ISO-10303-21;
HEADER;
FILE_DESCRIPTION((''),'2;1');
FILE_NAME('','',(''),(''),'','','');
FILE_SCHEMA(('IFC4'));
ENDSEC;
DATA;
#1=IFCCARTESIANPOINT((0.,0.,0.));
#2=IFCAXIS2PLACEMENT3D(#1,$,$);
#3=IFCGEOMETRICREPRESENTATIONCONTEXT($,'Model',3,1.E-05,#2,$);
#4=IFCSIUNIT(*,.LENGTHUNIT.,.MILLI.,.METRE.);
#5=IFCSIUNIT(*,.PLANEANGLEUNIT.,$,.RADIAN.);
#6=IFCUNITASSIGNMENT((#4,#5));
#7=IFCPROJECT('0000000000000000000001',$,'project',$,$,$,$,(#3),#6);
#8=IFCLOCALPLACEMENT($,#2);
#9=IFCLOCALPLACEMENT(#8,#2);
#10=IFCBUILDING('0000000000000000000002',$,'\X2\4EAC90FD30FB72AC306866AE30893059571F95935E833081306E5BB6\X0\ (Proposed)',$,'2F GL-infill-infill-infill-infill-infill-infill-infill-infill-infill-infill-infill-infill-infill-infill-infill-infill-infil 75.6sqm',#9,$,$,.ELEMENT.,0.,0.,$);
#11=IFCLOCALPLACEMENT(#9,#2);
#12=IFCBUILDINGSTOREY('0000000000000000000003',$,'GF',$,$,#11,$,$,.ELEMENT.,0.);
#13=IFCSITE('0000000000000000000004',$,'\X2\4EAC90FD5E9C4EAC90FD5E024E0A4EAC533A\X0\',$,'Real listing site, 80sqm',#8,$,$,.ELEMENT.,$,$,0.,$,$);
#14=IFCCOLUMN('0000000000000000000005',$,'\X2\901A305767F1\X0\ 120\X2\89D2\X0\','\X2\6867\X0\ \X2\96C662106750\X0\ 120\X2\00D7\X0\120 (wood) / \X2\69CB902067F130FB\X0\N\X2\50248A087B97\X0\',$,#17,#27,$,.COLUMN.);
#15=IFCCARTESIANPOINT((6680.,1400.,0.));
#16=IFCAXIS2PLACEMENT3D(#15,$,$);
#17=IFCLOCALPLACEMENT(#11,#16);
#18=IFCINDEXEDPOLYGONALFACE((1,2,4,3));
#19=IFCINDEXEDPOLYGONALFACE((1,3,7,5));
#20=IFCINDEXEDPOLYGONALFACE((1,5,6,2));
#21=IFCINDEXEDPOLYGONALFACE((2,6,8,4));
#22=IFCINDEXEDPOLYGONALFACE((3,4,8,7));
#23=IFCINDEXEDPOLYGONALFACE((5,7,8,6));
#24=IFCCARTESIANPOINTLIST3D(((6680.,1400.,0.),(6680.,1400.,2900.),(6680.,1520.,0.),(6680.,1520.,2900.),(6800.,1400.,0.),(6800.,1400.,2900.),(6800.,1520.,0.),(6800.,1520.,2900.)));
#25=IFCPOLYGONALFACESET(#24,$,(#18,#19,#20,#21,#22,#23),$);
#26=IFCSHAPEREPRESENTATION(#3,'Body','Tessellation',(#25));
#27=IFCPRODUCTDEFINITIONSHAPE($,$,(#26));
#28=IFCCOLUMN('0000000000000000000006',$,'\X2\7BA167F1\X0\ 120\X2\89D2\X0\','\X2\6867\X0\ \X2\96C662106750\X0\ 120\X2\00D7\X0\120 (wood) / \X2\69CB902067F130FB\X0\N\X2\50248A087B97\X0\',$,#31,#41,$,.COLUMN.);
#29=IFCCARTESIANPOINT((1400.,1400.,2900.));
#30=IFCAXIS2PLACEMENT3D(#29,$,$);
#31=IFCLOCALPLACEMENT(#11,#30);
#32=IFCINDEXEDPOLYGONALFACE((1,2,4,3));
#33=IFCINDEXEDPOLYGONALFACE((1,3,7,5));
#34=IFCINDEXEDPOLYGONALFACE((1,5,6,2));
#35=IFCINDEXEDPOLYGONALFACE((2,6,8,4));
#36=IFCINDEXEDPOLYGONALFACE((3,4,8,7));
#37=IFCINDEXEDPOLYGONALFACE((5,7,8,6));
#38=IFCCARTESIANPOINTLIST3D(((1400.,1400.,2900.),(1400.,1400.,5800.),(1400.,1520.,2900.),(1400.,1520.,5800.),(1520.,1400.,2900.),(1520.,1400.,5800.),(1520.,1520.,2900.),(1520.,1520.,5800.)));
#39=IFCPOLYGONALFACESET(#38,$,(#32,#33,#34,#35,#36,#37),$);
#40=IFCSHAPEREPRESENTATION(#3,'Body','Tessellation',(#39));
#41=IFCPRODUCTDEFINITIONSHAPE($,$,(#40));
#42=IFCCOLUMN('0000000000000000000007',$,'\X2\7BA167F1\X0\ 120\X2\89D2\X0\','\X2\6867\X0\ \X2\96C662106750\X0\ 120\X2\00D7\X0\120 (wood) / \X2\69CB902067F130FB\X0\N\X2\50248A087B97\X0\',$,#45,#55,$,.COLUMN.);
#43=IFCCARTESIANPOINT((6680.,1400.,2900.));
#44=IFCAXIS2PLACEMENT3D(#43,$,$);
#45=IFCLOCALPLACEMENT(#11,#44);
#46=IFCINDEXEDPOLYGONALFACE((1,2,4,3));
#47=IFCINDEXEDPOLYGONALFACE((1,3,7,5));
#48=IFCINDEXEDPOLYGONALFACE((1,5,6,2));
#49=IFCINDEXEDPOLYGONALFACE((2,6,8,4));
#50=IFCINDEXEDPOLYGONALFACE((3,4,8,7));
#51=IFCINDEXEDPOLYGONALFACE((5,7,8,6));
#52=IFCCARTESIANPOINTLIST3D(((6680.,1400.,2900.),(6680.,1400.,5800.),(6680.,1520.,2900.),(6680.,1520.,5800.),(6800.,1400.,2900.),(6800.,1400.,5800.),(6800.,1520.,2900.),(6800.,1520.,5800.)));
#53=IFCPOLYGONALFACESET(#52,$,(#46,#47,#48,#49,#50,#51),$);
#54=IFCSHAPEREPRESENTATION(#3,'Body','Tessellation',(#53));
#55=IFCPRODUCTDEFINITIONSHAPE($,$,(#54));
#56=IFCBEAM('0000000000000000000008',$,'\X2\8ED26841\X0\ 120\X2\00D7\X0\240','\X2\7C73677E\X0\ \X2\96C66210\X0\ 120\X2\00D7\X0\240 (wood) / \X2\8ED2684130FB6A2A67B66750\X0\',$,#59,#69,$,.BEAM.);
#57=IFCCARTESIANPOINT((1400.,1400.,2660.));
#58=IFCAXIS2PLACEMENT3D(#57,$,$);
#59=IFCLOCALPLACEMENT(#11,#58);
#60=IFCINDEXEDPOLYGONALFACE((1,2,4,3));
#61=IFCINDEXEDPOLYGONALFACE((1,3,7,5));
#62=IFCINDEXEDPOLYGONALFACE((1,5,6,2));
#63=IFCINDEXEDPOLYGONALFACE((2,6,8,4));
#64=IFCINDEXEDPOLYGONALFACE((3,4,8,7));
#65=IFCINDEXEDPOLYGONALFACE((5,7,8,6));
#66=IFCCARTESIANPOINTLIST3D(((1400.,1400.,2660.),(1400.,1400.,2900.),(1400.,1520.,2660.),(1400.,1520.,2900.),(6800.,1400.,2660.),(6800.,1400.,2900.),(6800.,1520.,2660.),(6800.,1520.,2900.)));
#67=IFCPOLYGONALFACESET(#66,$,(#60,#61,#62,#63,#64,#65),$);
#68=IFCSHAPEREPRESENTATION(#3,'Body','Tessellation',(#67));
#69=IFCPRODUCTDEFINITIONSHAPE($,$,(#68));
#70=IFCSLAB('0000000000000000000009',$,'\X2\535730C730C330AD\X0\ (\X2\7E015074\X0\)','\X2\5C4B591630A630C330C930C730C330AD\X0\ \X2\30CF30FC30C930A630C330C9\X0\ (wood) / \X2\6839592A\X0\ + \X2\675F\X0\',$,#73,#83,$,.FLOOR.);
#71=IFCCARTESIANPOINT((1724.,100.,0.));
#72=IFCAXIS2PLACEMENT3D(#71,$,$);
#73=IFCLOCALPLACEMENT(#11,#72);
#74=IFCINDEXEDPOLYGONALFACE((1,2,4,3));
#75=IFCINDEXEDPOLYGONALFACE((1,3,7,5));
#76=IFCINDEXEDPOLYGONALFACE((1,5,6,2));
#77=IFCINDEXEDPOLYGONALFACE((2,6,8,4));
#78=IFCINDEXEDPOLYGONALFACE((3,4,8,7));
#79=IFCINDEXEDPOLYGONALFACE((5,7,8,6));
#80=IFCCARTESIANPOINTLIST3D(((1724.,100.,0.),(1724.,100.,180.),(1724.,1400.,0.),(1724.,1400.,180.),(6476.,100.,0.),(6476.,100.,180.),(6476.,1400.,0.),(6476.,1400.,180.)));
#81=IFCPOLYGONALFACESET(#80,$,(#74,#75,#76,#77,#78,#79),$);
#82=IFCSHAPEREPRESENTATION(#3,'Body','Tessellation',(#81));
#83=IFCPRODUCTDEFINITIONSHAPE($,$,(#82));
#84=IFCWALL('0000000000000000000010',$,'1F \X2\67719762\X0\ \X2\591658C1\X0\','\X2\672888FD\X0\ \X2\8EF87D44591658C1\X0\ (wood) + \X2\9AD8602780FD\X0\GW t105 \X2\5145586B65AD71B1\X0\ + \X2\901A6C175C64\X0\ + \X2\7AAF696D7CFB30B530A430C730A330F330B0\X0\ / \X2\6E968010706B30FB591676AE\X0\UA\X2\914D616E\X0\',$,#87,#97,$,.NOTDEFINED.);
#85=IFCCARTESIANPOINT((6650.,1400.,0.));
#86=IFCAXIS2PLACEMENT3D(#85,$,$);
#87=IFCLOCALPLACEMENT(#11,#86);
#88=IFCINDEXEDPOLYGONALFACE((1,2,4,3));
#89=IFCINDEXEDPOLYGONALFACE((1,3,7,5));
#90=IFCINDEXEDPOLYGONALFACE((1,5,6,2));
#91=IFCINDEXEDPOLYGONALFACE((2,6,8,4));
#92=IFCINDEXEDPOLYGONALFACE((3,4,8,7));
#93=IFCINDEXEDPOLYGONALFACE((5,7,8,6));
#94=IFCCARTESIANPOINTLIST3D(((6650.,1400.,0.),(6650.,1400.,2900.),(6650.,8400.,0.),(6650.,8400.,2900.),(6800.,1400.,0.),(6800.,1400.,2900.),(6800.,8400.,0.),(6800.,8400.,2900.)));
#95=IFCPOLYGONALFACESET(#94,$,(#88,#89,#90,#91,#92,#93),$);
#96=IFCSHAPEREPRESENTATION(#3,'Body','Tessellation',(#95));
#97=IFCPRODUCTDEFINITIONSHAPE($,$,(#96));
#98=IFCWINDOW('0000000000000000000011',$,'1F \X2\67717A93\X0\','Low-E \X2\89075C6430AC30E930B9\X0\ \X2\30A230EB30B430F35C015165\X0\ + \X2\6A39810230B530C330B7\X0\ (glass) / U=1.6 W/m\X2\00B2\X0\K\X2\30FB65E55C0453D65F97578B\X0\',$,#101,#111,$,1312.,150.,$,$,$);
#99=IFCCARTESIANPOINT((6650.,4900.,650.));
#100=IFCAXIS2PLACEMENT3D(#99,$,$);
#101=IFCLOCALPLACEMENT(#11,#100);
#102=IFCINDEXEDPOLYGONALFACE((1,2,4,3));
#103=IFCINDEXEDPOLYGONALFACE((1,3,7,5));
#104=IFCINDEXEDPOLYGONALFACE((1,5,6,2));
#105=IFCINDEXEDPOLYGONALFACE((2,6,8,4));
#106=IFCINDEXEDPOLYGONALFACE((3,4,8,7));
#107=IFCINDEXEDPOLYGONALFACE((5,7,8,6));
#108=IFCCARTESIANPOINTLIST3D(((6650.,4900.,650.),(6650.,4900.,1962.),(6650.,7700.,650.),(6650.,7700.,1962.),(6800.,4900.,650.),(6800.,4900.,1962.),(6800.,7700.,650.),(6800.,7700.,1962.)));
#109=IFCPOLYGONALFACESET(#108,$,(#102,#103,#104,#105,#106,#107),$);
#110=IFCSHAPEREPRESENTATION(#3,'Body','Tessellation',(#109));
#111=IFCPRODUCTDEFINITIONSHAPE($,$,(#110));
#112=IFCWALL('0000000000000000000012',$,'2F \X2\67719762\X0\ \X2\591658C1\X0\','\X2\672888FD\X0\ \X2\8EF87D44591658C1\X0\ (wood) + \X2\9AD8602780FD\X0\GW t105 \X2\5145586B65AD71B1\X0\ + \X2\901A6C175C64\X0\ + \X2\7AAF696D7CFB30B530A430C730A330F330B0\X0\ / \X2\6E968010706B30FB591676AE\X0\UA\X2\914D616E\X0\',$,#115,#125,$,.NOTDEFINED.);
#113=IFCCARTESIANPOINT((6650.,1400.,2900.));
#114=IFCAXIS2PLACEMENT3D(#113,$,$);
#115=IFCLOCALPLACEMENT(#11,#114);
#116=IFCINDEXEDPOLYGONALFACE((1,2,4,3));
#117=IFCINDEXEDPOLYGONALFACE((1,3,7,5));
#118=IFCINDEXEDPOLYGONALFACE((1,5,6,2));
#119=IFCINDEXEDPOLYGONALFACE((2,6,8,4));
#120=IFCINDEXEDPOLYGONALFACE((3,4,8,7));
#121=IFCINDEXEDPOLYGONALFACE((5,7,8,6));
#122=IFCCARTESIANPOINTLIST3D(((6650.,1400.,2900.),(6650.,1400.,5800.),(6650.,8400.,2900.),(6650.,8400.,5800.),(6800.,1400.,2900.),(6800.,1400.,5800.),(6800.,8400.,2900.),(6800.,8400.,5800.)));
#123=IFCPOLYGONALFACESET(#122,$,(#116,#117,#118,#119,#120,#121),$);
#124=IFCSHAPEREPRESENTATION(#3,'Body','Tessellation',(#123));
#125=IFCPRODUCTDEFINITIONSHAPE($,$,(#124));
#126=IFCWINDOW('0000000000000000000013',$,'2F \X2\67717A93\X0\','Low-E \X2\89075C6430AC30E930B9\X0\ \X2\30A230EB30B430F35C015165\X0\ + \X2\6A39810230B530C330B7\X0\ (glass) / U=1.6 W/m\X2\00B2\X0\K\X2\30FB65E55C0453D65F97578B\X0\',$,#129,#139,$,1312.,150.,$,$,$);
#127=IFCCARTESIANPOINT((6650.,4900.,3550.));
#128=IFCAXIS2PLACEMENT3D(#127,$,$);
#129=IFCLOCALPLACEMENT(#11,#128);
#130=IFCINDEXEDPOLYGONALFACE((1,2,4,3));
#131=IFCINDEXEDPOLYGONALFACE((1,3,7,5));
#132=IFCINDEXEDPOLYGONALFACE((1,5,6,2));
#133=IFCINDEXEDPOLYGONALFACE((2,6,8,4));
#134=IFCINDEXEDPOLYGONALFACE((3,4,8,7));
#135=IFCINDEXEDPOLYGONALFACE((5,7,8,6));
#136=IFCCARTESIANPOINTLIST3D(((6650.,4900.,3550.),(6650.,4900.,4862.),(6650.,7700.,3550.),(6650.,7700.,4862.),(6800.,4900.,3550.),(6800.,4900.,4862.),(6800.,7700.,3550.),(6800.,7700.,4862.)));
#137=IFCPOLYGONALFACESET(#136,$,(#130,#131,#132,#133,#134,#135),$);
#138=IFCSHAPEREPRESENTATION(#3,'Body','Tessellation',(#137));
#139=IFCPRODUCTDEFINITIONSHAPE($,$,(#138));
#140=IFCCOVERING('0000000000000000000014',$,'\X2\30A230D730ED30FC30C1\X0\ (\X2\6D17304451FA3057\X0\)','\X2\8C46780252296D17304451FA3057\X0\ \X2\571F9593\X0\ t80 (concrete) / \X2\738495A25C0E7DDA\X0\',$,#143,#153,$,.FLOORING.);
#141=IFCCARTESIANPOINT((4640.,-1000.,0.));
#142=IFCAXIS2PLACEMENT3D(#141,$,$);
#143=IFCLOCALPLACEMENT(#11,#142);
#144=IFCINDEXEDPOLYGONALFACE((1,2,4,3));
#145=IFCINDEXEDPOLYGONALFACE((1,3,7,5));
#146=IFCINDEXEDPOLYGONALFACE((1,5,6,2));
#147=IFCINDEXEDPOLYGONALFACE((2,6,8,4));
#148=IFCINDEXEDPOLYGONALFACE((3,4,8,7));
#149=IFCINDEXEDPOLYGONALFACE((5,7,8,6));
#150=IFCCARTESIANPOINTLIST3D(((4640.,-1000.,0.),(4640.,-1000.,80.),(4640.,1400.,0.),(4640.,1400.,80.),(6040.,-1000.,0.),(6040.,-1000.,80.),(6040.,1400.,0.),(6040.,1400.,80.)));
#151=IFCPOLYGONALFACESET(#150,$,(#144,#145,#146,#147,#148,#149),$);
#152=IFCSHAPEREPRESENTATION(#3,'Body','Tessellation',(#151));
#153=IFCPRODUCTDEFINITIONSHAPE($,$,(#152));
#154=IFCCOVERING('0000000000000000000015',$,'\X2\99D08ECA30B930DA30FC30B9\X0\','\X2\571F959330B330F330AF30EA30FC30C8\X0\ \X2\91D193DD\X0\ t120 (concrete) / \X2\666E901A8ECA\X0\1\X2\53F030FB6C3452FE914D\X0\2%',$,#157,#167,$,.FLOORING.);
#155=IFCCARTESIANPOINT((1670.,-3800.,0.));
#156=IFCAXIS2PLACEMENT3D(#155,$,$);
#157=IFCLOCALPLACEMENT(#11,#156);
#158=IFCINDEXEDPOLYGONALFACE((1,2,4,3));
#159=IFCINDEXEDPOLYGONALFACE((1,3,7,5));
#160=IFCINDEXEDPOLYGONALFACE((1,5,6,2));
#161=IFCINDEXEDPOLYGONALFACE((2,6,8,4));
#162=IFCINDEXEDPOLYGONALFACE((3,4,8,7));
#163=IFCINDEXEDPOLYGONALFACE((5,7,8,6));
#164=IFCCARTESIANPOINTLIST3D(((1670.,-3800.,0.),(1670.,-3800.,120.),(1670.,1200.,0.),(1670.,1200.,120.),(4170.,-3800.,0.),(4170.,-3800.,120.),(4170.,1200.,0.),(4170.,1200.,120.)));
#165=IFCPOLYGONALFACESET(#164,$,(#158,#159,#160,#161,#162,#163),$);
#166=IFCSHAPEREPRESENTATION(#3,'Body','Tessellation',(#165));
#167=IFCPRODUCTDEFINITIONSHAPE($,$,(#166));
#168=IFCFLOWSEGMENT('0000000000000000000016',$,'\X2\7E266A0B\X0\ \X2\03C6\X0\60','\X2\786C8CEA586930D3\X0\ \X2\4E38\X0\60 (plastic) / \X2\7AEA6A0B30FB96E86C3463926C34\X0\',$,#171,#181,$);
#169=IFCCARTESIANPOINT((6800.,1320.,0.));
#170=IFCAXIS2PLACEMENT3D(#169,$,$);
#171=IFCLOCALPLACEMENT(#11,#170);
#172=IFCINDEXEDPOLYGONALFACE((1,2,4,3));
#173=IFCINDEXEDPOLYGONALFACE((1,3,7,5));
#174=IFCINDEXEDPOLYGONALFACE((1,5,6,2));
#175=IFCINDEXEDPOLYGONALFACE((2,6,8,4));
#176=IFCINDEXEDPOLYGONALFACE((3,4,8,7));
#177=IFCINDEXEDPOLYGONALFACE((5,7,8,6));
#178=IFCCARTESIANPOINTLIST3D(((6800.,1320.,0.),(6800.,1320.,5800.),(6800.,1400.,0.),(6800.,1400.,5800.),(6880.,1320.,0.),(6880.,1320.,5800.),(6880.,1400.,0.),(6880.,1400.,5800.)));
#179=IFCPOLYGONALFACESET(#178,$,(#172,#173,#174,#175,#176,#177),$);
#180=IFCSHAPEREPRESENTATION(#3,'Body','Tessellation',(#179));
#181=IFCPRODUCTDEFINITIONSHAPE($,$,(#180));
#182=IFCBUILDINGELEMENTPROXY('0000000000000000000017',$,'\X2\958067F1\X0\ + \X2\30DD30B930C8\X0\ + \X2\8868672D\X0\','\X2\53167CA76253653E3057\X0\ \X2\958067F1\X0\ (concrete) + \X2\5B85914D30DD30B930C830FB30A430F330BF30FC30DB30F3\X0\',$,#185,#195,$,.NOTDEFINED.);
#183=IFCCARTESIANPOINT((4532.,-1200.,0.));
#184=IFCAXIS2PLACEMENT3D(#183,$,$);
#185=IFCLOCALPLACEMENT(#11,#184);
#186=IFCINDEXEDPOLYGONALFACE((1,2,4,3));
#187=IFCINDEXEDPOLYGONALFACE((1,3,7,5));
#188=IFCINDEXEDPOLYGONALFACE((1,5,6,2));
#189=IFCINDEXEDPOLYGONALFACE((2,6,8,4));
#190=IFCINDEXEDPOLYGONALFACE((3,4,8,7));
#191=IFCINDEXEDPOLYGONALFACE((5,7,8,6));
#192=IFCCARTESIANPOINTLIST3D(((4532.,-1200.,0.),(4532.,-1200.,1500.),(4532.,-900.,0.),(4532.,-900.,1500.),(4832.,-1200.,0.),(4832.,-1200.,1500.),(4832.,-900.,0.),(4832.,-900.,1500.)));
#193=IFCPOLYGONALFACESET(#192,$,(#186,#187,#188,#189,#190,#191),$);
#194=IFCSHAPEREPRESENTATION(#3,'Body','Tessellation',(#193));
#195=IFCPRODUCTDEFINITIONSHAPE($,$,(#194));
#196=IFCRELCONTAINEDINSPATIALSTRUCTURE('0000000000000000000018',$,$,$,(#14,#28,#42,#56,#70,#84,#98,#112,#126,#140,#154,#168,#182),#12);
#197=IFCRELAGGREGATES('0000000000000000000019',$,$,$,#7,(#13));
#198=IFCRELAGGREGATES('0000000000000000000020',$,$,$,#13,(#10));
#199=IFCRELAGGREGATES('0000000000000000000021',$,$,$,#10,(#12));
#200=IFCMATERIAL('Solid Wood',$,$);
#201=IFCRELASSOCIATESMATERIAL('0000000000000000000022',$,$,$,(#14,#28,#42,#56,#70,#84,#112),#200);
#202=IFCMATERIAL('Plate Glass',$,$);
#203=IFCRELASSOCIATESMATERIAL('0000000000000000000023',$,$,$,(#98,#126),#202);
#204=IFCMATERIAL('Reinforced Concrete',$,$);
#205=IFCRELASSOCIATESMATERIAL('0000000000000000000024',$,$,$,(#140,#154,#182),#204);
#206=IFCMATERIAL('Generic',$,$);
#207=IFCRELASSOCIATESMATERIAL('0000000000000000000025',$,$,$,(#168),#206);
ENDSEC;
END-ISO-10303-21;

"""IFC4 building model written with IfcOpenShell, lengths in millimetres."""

from ifc_helpers import new_model, si_unit, frame, frame_2d, origin, place, context, project, spatial, rectangle, extrude, material, element, fill, save


model = new_model("IFC4")

# Units and contexts
model_context = context("Model", 3, precision=1e-05, world=origin())
ifc_project = project(units=[si_unit("LENGTHUNIT", "METRE", prefix="MILLI"), si_unit("PLANEANGLEUNIT", "RADIAN")], contexts=[model_context])

# Site, building, storey
site_placement = place(None, origin())
site = spatial("IfcSite", under=ifc_project, at=site_placement, Name="京都府京都市上京区", ObjectType="Real listing site, 80sqm", CompositionType="ELEMENT", RefElevation=0.0)
building_placement = place(site_placement, origin())
building = spatial("IfcBuilding", under=site, at=building_placement, Name="京都・犬と暮らす土間広めの家 (Proposed)", ObjectType="2F GL-infill-infill-infill-infill-infill-infill-infill-infill-infill-infill-infill-infill-infill-infill-infill-infill-infil 75.6sqm", CompositionType="ELEMENT", ElevationOfRefHeight=0.0, ElevationOfTerrain=0.0)
storey_placement = place(building_placement, origin())
storey = spatial("IfcBuildingStorey", under=building, at=storey_placement, Name="GF", CompositionType="ELEMENT", Elevation=0.0)

# Columns
ifc_material_1 = material(Name="Solid Wood")
column_1_placement = place(storey_placement, frame((6680.0, 1400.0, 0.0)))
element("IfcColumn", 1, at=column_1_placement, inside=storey, material=ifc_material_1, Name="通し柱 120角", Description="桧 集成材 120×120 (wood) / 構造柱・N値計算", PredefinedType="COLUMN", context=model_context, shape_type="SweptSolid", body=[
    extrude(rectangle(XDim=120.0, YDim=120.0, at=frame_2d((60.0, 60.0))), frame((6680.0, 1400.0, 0.0)), (0.0, 0.0, 1.0), 2900.0),
])
column_2_placement = place(storey_placement, frame((1400.0, 1400.0, 2900.0)))
element("IfcColumn", 2, at=column_2_placement, inside=storey, material=ifc_material_1, Name="管柱 120角", Description="桧 集成材 120×120 (wood) / 構造柱・N値計算", PredefinedType="COLUMN", context=model_context, shape_type="SweptSolid", body=[
    extrude(rectangle(XDim=120.0, YDim=120.0, at=frame_2d((60.0, 60.0))), frame((1400.0, 1400.0, 2900.0)), (0.0, 0.0, 1.0), 2900.0),
])
column_3_placement = place(storey_placement, frame((6680.0, 1400.0, 2900.0)))
element("IfcColumn", 3, at=column_3_placement, inside=storey, material=ifc_material_1, Name="管柱 120角", Description="桧 集成材 120×120 (wood) / 構造柱・N値計算", PredefinedType="COLUMN", context=model_context, shape_type="SweptSolid", body=[
    extrude(rectangle(XDim=120.0, YDim=120.0, at=frame_2d((60.0, 60.0))), frame((6680.0, 1400.0, 2900.0)), (0.0, 0.0, 1.0), 2900.0),
])

# Beam
beam_1_placement = place(storey_placement, frame((1400.0, 1400.0, 2660.0)))
element("IfcBeam", 4, at=beam_1_placement, inside=storey, material=ifc_material_1, Name="軒桁 120×240", Description="米松 集成 120×240 (wood) / 軒桁・横架材", PredefinedType="BEAM", context=model_context, shape_type="SweptSolid", body=[
    extrude(rectangle(XDim=5400.0, YDim=120.0, at=frame_2d((2700.0, 60.0))), frame((1400.0, 1400.0, 2660.0)), (0.0, 0.0, 1.0), 240.0),
])

# Slab
slab_placement = place(storey_placement, frame((1724.0, 100.0, 0.0)))
element("IfcSlab", 5, at=slab_placement, inside=storey, material=ifc_material_1, Name="南デッキ (縁側)", Description="屋外ウッドデッキ ハードウッド (wood) / 根太 + 束", PredefinedType="FLOOR", context=model_context, shape_type="SweptSolid", body=[
    extrude(rectangle(XDim=4752.0, YDim=1300.0, at=frame_2d((2376.0, 650.0))), frame((1724.0, 100.0, 0.0)), (0.0, 0.0, 1.0), 180.0),
])

# Walls, openings, windows
wall_1_placement = place(storey_placement, frame((6650.0, 1400.0, 0.0)))
wall_1 = element("IfcWall", 6, at=wall_1_placement, inside=storey, material=ifc_material_1, Name="1F 東面 外壁", Description="木製 軸組外壁 (wood) + 高性能GW t105 充填断熱 + 通気層 + 窯業系サイディング / 準耐火・外皮UA配慮", PredefinedType="NOTDEFINED", context=model_context, shape_type="SweptSolid", body=[
    extrude(rectangle(XDim=150.0, YDim=7000.0, at=frame_2d((75.0, 3500.0))), frame((6650.0, 1400.0, 0.0)), (0.0, 0.0, 1.0), 2900.0),
])
opening_1_placement = place(storey_placement, frame((6650.0, 4900.0, 650.0)))
opening_1 = element("IfcOpeningElement", 7, at=opening_1_placement, cuts=wall_1, PredefinedType="NOTDEFINED", context=model_context, shape_type="SweptSolid", body=[
    extrude(rectangle(XDim=150.0, YDim=2800.0, at=frame_2d((75.0, 1400.0))), frame((6650.0, 4900.0, 650.0)), (0.0, 0.0, 1.0), 1312.0),
])
ifc_material_2 = material(Name="Plate Glass")
window_1_placement = place(storey_placement, frame((6650.0, 4900.0, 650.0)))
window_1 = element("IfcWindow", 8, at=window_1_placement, inside=storey, material=ifc_material_2, Name="1F 東窓", Description="Low-E 複層ガラス アルゴン封入 + 樹脂サッシ (glass) / U=1.6 W/m²K・日射取得型", OverallHeight=1312.0, OverallWidth=150.0, context=model_context, shape_type="SweptSolid", body=[
    extrude(rectangle(XDim=150.0, YDim=2800.0, at=frame_2d((75.0, 1400.0))), frame((6650.0, 4900.0, 650.0)), (0.0, 0.0, 1.0), 1312.0),
])
fill(opening_1, window_1)
wall_2_placement = place(storey_placement, frame((6650.0, 1400.0, 2900.0)))
wall_2 = element("IfcWall", 9, at=wall_2_placement, inside=storey, material=ifc_material_1, Name="2F 東面 外壁", Description="木製 軸組外壁 (wood) + 高性能GW t105 充填断熱 + 通気層 + 窯業系サイディング / 準耐火・外皮UA配慮", PredefinedType="NOTDEFINED", context=model_context, shape_type="SweptSolid", body=[
    extrude(rectangle(XDim=150.0, YDim=7000.0, at=frame_2d((75.0, 3500.0))), frame((6650.0, 1400.0, 2900.0)), (0.0, 0.0, 1.0), 2900.0),
])
opening_2_placement = place(storey_placement, frame((6650.0, 4900.0, 3550.0)))
opening_2 = element("IfcOpeningElement", 10, at=opening_2_placement, cuts=wall_2, PredefinedType="NOTDEFINED", context=model_context, shape_type="SweptSolid", body=[
    extrude(rectangle(XDim=150.0, YDim=2800.0, at=frame_2d((75.0, 1400.0))), frame((6650.0, 4900.0, 3550.0)), (0.0, 0.0, 1.0), 1312.0),
])
window_2_placement = place(storey_placement, frame((6650.0, 4900.0, 3550.0)))
window_2 = element("IfcWindow", 11, at=window_2_placement, inside=storey, material=ifc_material_2, Name="2F 東窓", Description="Low-E 複層ガラス アルゴン封入 + 樹脂サッシ (glass) / U=1.6 W/m²K・日射取得型", OverallHeight=1312.0, OverallWidth=150.0, context=model_context, shape_type="SweptSolid", body=[
    extrude(rectangle(XDim=150.0, YDim=2800.0, at=frame_2d((75.0, 1400.0))), frame((6650.0, 4900.0, 3550.0)), (0.0, 0.0, 1.0), 1312.0),
])
fill(opening_2, window_2)

# Coverings
ifc_material_3 = material(Name="Reinforced Concrete")
covering_1_placement = place(storey_placement, frame((4640.0, -1000.0, 0.0)))
element("IfcCovering", 12, at=covering_1_placement, inside=storey, material=ifc_material_3, Name="アプローチ (洗い出し)", Description="豆砂利洗い出し 土間 t80 (concrete) / 玄関導線", PredefinedType="FLOORING", context=model_context, shape_type="SweptSolid", body=[
    extrude(rectangle(XDim=1400.0, YDim=2400.0, at=frame_2d((700.0, 1200.0))), frame((4640.0, -1000.0, 0.0)), (0.0, 0.0, 1.0), 80.0),
])
covering_2_placement = place(storey_placement, frame((1670.0, -3800.0, 0.0)))
element("IfcCovering", 13, at=covering_2_placement, inside=storey, material=ifc_material_3, Name="駐車スペース", Description="土間コンクリート 金鏝 t120 (concrete) / 普通車1台・水勾配2%", PredefinedType="FLOORING", context=model_context, shape_type="SweptSolid", body=[
    extrude(rectangle(XDim=2500.0, YDim=5000.0, at=frame_2d((1250.0, 2500.0))), frame((1670.0, -3800.0, 0.0)), (0.0, 0.0, 1.0), 120.0),
])

# Flow segment
ifc_material_4 = material(Name="Generic")
flow_segment_placement = place(storey_placement, frame((6800.0, 1320.0, 0.0)))
element("IfcFlowSegment", 14, at=flow_segment_placement, inside=storey, material=ifc_material_4, Name="縦樋 φ60", Description="硬質塩ビ 丸60 (plastic) / 竪樋・雨水排水", context=model_context, shape_type="SweptSolid", body=[
    extrude(rectangle(XDim=80.0, YDim=80.0, at=frame_2d((40.0, 40.0))), frame((6800.0, 1320.0, 0.0)), (0.0, 0.0, 1.0), 5800.0),
])

# Building element proxy
proxy_placement = place(storey_placement, frame((4532.0, -1200.0, 0.0)))
element("IfcBuildingElementProxy", 15, at=proxy_placement, inside=storey, material=ifc_material_3, Name="門柱 + ポスト + 表札", Description="化粧打放し 門柱 (concrete) + 宅配ポスト・インターホン", PredefinedType="NOTDEFINED", context=model_context, shape_type="SweptSolid", body=[
    extrude(rectangle(XDim=300.0, YDim=300.0, at=frame_2d((150.0, 150.0))), frame((4532.0, -1200.0, 0.0)), (0.0, 0.0, 1.0), 1500.0),
])

save(model, "model.ifc")
